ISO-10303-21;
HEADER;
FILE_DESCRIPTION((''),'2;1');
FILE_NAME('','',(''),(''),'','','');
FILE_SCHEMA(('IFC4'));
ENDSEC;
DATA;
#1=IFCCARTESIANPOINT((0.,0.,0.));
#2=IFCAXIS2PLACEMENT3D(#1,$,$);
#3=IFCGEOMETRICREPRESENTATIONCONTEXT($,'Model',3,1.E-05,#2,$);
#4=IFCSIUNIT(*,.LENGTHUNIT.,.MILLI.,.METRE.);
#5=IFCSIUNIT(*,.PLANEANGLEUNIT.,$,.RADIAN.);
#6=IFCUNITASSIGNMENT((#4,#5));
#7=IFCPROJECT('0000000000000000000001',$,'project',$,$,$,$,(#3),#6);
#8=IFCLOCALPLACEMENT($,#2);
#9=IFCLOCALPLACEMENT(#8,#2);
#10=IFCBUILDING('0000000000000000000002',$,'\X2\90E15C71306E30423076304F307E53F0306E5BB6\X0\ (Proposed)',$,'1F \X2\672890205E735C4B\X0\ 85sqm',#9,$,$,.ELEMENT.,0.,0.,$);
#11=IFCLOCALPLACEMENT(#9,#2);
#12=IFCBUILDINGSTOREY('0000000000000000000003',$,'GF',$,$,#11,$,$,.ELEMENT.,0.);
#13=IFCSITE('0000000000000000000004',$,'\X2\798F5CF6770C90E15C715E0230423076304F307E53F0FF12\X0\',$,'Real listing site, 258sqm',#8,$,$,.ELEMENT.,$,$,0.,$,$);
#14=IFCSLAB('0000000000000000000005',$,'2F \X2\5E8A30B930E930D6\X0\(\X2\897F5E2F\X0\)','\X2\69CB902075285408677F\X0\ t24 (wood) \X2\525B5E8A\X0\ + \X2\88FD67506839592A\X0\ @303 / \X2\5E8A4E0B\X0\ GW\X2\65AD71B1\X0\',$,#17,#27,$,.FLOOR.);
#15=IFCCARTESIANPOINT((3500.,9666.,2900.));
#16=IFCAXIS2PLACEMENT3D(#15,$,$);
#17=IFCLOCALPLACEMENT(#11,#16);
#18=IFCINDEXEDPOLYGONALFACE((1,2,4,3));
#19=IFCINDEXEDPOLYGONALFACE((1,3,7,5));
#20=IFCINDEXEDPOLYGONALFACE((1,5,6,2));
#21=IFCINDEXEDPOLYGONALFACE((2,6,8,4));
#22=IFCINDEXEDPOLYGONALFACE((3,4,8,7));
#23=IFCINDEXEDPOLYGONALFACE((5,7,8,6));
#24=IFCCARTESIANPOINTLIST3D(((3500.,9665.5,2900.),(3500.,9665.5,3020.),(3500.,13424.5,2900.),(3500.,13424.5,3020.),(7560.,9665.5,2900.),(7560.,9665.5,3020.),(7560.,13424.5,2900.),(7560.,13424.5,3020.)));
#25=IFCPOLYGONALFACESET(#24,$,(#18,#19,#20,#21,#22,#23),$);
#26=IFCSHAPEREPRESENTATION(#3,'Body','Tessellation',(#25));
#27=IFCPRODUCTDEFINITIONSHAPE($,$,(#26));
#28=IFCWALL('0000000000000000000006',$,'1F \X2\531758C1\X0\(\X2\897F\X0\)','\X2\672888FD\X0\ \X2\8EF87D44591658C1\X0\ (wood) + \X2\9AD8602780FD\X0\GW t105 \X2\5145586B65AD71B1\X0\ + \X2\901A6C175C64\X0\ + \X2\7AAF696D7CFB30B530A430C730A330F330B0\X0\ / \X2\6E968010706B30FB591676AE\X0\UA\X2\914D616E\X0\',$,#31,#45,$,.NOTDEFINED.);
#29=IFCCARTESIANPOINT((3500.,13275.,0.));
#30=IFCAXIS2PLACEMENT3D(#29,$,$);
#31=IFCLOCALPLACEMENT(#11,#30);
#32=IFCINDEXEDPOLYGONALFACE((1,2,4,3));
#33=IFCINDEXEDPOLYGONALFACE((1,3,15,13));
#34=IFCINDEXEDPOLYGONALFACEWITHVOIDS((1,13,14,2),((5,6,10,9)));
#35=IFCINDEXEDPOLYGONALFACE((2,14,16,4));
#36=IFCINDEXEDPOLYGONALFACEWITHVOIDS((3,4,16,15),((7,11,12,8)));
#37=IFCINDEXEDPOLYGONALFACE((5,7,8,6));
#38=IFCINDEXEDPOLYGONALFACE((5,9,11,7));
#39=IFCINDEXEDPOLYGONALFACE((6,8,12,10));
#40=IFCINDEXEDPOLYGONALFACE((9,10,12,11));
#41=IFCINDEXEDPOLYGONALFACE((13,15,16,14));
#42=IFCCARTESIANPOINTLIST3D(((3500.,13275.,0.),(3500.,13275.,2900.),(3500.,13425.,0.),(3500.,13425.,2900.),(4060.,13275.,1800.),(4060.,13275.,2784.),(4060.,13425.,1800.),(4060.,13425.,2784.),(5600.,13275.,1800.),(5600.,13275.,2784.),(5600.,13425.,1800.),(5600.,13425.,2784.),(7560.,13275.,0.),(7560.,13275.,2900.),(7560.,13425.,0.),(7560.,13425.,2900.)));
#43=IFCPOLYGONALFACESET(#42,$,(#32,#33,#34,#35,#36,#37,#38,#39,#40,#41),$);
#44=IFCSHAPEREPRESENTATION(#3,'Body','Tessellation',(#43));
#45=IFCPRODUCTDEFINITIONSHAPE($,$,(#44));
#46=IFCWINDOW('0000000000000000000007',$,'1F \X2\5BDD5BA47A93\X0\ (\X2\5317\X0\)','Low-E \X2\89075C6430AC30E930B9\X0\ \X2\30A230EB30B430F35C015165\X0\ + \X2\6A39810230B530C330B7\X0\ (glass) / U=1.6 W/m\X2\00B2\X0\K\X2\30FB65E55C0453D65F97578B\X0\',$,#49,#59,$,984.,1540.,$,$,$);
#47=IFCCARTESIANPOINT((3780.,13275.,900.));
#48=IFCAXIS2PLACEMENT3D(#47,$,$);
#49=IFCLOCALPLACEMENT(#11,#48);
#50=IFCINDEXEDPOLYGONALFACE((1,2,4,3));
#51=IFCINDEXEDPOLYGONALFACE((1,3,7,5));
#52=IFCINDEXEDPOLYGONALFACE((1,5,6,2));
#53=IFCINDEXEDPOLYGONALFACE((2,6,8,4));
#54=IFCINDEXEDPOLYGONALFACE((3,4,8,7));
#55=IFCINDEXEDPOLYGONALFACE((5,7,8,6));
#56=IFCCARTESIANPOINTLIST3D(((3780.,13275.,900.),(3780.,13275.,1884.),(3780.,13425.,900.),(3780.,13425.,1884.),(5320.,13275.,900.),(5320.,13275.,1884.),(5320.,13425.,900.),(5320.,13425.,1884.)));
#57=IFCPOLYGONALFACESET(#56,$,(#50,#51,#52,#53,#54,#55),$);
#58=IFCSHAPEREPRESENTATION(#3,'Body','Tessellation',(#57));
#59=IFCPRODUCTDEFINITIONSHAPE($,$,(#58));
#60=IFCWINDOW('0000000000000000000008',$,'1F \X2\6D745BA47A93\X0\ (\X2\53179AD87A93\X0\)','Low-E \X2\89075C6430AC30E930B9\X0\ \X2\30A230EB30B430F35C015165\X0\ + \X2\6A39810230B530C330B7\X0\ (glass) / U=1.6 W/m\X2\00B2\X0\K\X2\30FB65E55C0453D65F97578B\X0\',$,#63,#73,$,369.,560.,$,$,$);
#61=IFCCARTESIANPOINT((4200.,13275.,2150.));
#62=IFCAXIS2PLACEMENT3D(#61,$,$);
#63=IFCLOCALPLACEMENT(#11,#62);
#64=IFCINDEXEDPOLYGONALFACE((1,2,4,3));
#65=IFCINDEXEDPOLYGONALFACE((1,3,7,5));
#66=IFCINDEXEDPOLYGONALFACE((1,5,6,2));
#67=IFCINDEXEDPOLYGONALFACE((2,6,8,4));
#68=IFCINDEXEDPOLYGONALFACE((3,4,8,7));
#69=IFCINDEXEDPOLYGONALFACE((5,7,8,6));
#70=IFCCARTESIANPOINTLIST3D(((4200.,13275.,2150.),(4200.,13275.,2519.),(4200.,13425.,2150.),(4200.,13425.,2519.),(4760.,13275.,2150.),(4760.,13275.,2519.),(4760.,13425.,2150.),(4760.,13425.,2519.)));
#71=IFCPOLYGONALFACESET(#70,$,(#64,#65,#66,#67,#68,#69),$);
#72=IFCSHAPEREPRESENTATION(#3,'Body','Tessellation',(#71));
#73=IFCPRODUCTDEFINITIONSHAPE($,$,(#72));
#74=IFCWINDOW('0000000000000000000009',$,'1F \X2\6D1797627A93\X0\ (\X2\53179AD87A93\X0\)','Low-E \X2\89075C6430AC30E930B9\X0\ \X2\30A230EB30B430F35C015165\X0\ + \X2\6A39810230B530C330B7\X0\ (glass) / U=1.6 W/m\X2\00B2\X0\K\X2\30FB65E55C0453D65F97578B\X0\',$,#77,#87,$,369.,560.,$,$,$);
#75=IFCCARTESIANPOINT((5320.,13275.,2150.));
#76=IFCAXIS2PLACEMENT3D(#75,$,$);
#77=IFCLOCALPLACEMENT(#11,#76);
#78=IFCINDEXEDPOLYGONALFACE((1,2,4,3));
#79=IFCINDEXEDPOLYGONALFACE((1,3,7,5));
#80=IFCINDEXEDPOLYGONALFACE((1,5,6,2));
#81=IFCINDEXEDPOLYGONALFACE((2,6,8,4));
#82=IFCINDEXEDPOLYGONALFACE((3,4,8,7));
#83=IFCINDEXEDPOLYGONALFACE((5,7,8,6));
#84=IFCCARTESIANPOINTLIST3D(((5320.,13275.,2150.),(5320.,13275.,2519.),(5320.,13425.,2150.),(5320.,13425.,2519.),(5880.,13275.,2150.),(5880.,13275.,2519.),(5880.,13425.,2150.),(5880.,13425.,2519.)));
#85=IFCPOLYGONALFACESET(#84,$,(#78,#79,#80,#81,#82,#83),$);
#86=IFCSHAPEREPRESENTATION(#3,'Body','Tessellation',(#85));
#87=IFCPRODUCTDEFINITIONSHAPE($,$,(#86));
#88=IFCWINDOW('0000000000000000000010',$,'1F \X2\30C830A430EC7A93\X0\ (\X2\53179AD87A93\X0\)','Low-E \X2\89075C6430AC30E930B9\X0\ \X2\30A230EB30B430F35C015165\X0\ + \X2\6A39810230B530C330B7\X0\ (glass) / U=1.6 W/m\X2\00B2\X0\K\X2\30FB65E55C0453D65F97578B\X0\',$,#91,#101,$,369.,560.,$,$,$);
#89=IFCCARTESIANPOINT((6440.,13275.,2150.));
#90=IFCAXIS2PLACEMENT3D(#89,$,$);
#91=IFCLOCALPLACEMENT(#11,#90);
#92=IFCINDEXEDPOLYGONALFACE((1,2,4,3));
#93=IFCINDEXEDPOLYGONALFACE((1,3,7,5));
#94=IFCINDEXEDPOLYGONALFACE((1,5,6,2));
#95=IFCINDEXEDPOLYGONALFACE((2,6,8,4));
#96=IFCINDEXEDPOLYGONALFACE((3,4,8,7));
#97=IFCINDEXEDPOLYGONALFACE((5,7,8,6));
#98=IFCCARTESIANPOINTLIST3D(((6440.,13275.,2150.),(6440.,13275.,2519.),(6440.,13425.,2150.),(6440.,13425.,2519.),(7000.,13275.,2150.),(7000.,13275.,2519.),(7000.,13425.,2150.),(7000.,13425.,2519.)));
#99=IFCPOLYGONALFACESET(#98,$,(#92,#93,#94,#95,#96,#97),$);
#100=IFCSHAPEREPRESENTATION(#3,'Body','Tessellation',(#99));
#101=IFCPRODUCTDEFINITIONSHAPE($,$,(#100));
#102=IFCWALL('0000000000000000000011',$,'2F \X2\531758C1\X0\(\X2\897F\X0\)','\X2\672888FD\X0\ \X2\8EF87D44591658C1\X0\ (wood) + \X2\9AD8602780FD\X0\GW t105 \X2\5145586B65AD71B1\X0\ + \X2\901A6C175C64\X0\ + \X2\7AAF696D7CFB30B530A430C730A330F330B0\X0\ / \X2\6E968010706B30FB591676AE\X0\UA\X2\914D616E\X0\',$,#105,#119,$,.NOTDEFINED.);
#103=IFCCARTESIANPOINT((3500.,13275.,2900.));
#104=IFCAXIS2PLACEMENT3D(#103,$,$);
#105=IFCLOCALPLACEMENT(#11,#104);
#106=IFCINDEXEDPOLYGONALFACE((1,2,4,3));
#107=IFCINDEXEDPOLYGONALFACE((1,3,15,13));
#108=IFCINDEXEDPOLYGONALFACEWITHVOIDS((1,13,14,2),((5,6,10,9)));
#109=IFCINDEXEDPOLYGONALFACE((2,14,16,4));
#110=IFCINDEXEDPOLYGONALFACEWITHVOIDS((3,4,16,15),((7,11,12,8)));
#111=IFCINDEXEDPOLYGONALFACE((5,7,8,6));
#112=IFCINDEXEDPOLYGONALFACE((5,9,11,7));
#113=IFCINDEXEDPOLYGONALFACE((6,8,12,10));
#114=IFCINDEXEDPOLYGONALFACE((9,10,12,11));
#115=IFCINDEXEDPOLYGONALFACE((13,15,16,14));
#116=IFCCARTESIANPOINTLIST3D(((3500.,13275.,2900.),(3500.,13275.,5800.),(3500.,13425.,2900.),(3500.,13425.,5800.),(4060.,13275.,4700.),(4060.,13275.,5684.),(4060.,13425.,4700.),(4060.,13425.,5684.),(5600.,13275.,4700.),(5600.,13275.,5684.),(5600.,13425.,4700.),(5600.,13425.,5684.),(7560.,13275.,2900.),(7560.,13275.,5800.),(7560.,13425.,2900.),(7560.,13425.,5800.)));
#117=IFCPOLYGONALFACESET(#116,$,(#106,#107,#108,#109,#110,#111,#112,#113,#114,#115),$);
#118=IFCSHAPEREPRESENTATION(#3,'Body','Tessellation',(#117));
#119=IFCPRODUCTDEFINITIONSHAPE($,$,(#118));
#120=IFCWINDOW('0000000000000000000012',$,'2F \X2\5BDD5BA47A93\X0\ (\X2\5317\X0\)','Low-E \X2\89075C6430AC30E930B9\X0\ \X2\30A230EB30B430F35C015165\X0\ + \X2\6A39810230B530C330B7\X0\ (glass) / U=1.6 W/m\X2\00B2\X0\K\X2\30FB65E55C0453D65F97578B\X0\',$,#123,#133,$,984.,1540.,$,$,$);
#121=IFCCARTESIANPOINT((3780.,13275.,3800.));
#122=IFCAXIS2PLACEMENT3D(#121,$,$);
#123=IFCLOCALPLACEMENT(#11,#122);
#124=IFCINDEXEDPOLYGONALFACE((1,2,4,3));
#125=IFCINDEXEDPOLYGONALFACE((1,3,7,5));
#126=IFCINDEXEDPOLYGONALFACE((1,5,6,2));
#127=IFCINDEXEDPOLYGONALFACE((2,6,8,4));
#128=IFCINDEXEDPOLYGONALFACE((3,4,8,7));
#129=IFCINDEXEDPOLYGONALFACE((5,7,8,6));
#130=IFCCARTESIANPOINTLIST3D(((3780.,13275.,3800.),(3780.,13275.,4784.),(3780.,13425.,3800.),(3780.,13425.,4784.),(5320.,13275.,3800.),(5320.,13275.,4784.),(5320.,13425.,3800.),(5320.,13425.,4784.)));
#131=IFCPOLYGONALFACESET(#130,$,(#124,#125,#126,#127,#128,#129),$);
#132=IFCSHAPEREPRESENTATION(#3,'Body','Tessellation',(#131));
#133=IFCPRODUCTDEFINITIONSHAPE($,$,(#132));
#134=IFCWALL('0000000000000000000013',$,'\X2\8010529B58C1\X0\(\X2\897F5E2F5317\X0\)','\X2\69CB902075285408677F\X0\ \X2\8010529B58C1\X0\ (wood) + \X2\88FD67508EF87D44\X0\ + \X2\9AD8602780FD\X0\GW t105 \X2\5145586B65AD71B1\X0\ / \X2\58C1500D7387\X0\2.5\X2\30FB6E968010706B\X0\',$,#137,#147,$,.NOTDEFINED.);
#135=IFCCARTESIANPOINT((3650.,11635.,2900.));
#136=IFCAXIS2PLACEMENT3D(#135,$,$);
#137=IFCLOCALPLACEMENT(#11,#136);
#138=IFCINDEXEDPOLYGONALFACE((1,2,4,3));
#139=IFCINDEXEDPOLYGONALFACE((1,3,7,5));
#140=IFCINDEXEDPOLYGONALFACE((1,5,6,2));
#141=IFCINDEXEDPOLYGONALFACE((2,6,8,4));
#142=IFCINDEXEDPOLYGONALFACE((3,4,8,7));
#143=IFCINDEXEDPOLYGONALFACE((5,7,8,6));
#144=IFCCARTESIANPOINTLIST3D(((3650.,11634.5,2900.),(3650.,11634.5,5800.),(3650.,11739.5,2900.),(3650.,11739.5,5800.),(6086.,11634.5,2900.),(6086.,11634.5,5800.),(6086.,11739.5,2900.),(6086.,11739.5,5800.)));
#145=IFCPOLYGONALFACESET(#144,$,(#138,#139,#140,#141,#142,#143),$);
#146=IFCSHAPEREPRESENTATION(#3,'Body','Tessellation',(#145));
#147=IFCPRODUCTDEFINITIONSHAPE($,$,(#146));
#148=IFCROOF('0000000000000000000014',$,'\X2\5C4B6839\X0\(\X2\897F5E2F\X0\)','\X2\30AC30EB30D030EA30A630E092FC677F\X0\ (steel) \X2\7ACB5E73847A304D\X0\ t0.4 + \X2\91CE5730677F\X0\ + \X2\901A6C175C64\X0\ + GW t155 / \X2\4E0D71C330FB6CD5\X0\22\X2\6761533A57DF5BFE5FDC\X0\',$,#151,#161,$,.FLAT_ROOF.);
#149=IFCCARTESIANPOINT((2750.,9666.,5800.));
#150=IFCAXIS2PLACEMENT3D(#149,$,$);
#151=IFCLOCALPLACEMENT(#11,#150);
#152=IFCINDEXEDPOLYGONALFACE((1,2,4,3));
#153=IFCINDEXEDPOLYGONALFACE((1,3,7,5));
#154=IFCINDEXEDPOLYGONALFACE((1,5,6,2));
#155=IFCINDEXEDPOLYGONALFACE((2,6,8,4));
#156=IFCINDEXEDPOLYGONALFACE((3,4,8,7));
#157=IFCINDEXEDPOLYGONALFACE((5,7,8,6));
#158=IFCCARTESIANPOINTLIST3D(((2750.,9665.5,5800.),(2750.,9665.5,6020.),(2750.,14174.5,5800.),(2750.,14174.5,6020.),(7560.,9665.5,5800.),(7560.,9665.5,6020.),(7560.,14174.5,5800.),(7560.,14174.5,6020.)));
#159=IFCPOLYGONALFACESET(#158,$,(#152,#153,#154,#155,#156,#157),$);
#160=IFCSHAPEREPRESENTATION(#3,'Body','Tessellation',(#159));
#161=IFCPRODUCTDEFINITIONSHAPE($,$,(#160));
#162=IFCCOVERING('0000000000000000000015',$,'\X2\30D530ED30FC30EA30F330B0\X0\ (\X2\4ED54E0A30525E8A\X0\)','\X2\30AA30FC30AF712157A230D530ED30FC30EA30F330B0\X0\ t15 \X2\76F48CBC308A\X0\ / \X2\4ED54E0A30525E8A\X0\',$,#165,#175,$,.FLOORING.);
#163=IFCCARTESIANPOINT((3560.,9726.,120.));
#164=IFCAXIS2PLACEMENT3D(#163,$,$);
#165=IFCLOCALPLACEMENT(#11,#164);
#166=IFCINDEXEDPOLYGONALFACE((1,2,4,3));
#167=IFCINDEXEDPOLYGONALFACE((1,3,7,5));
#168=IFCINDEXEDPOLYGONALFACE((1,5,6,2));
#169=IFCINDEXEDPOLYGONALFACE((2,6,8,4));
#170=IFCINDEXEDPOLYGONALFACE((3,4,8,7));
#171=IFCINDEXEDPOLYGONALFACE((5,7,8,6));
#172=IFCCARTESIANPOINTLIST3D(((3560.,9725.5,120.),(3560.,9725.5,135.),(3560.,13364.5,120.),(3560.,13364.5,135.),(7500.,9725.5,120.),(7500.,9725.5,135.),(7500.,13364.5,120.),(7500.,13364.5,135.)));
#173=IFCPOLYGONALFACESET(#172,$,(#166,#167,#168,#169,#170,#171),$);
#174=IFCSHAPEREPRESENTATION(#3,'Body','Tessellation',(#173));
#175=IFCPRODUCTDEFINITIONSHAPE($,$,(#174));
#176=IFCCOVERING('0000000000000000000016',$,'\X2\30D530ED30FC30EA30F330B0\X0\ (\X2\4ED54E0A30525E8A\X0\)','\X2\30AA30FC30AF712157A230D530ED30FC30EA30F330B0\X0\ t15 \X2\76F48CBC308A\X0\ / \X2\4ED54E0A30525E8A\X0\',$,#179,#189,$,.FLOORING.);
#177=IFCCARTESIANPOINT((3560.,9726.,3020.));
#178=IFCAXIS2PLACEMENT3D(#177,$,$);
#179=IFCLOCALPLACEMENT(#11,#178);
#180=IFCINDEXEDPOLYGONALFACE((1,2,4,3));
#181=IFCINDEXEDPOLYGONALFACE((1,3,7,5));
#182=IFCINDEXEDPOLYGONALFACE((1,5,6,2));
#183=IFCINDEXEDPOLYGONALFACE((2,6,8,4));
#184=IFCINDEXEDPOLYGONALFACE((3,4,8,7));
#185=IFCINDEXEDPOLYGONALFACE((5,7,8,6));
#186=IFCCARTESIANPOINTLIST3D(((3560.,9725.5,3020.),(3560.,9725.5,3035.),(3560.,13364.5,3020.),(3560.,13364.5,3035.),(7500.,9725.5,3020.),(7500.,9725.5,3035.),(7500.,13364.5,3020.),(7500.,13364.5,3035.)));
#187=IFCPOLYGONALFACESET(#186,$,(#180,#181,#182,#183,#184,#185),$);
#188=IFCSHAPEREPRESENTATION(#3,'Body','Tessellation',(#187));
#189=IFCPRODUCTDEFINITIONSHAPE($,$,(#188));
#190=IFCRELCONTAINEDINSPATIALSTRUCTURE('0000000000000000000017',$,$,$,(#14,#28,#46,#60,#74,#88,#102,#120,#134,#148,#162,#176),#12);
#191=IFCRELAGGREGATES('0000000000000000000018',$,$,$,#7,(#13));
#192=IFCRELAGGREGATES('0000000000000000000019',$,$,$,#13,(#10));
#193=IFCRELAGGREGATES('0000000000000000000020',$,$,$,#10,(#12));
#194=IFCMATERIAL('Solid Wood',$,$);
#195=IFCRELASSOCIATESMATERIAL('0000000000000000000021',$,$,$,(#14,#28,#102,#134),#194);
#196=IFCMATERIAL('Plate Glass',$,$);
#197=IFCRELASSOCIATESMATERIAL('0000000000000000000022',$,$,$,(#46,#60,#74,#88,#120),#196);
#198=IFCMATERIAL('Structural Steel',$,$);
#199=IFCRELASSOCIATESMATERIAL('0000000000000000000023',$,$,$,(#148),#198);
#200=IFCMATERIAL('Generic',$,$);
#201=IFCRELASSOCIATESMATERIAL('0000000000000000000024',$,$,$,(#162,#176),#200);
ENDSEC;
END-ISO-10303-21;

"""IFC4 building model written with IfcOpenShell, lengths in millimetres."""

from ifc_helpers import new_model, si_unit, frame, frame_2d, origin, place, context, project, spatial, rectangle, extrude, material, element, fill, save


model = new_model("IFC4")

# Units and contexts
model_context = context("Model", 3, precision=1e-05, world=origin())
ifc_project = project(units=[si_unit("LENGTHUNIT", "METRE", prefix="MILLI"), si_unit("PLANEANGLEUNIT", "RADIAN")], contexts=[model_context])

# Site, building, storey
site_placement = place(None, origin())
site = spatial("IfcSite", under=ifc_project, at=site_placement, Name="福島県郡山市あぶくま台２", ObjectType="Real listing site, 258sqm", CompositionType="ELEMENT", RefElevation=0.0)
building_placement = place(site_placement, origin())
building = spatial("IfcBuilding", under=site, at=building_placement, Name="郡山のあぶくま台の家 (Proposed)", ObjectType="1F 木造平屋 85sqm", CompositionType="ELEMENT", ElevationOfRefHeight=0.0, ElevationOfTerrain=0.0)
storey_placement = place(building_placement, origin())
storey = spatial("IfcBuildingStorey", under=building, at=storey_placement, Name="GF", CompositionType="ELEMENT", Elevation=0.0)

# Slab
ifc_material_1 = material(Name="Solid Wood")
slab_1_placement = place(storey_placement, frame((3500.0, 9666.0, 2900.0)))
element("IfcSlab", 1, at=slab_1_placement, inside=storey, material=ifc_material_1, Name="2F 床スラブ(西帯)", Description="構造用合板 t24 (wood) 剛床 + 製材根太 @303 / 床下 GW断熱", PredefinedType="FLOOR", context=model_context, shape_type="SweptSolid", body=[
    extrude(rectangle(XDim=4060.0, YDim=3759.0, at=frame_2d((2030.0, 1879.0))), frame((3500.0, 9666.0, 2900.0)), (0.0, 0.0, 1.0), 120.0),
])

# Wall, openings, windows
wall_1_placement = place(storey_placement, frame((3500.0, 13275.0, 0.0)))
wall_1 = element("IfcWall", 2, at=wall_1_placement, inside=storey, material=ifc_material_1, Name="1F 北壁(西)", Description="木製 軸組外壁 (wood) + 高性能GW t105 充填断熱 + 通気層 + 窯業系サイディング / 準耐火・外皮UA配慮", PredefinedType="NOTDEFINED", context=model_context, shape_type="SweptSolid", body=[
    extrude(rectangle(XDim=4060.0, YDim=150.0, at=frame_2d((2030.0, 75.0))), frame((3500.0, 13275.0, 0.0)), (0.0, 0.0, 1.0), 2900.0),
])
opening_1_placement = place(storey_placement, frame((3780.0, 13275.0, 900.0)))
opening_1 = element("IfcOpeningElement", 3, at=opening_1_placement, cuts=wall_1, PredefinedType="NOTDEFINED", context=model_context, shape_type="SweptSolid", body=[
    extrude(rectangle(XDim=1540.0, YDim=150.0, at=frame_2d((770.0, 75.0))), frame((3780.0, 13275.0, 900.0)), (0.0, 0.0, 1.0), 984.0),
])
opening_2_placement = place(storey_placement, frame((4200.0, 13275.0, 2150.0)))
opening_2 = element("IfcOpeningElement", 4, at=opening_2_placement, cuts=wall_1, PredefinedType="NOTDEFINED", context=model_context, shape_type="SweptSolid", body=[
    extrude(rectangle(XDim=560.0, YDim=150.0, at=frame_2d((280.0, 75.0))), frame((4200.0, 13275.0, 2150.0)), (0.0, 0.0, 1.0), 369.0),
])
opening_3_placement = place(storey_placement, frame((5320.0, 13275.0, 2150.0)))
opening_3 = element("IfcOpeningElement", 5, at=opening_3_placement, cuts=wall_1, PredefinedType="NOTDEFINED", context=model_context, shape_type="SweptSolid", body=[
    extrude(rectangle(XDim=560.0, YDim=150.0, at=frame_2d((280.0, 75.0))), frame((5320.0, 13275.0, 2150.0)), (0.0, 0.0, 1.0), 369.0),
])
opening_4_placement = place(storey_placement, frame((6440.0, 13275.0, 2150.0)))
opening_4 = element("IfcOpeningElement", 6, at=opening_4_placement, cuts=wall_1, PredefinedType="NOTDEFINED", context=model_context, shape_type="SweptSolid", body=[
    extrude(rectangle(XDim=560.0, YDim=150.0, at=frame_2d((280.0, 75.0))), frame((6440.0, 13275.0, 2150.0)), (0.0, 0.0, 1.0), 369.0),
])
ifc_material_2 = material(Name="Plate Glass")
window_1_placement = place(storey_placement, frame((3780.0, 13275.0, 900.0)))
window_1 = element("IfcWindow", 7, at=window_1_placement, inside=storey, material=ifc_material_2, Name="1F 寝室窓 (北)", Description="Low-E 複層ガラス アルゴン封入 + 樹脂サッシ (glass) / U=1.6 W/m²K・日射取得型", OverallHeight=984.0, OverallWidth=1540.0, context=model_context, shape_type="SweptSolid", body=[
    extrude(rectangle(XDim=1540.0, YDim=150.0, at=frame_2d((770.0, 75.0))), frame((3780.0, 13275.0, 900.0)), (0.0, 0.0, 1.0), 984.0),
])
fill(opening_1, window_1)
window_2_placement = place(storey_placement, frame((4200.0, 13275.0, 2150.0)))
window_2 = element("IfcWindow", 8, at=window_2_placement, inside=storey, material=ifc_material_2, Name="1F 浴室窓 (北高窓)", Description="Low-E 複層ガラス アルゴン封入 + 樹脂サッシ (glass) / U=1.6 W/m²K・日射取得型", OverallHeight=369.0, OverallWidth=560.0, context=model_context, shape_type="SweptSolid", body=[
    extrude(rectangle(XDim=560.0, YDim=150.0, at=frame_2d((280.0, 75.0))), frame((4200.0, 13275.0, 2150.0)), (0.0, 0.0, 1.0), 369.0),
])
fill(opening_2, window_2)
window_3_placement = place(storey_placement, frame((5320.0, 13275.0, 2150.0)))
window_3 = element("IfcWindow", 9, at=window_3_placement, inside=storey, material=ifc_material_2, Name="1F 洗面窓 (北高窓)", Description="Low-E 複層ガラス アルゴン封入 + 樹脂サッシ (glass) / U=1.6 W/m²K・日射取得型", OverallHeight=369.0, OverallWidth=560.0, context=model_context, shape_type="SweptSolid", body=[
    extrude(rectangle(XDim=560.0, YDim=150.0, at=frame_2d((280.0, 75.0))), frame((5320.0, 13275.0, 2150.0)), (0.0, 0.0, 1.0), 369.0),
])
fill(opening_3, window_3)
window_4_placement = place(storey_placement, frame((6440.0, 13275.0, 2150.0)))
window_4 = element("IfcWindow", 10, at=window_4_placement, inside=storey, material=ifc_material_2, Name="1F トイレ窓 (北高窓)", Description="Low-E 複層ガラス アルゴン封入 + 樹脂サッシ (glass) / U=1.6 W/m²K・日射取得型", OverallHeight=369.0, OverallWidth=560.0, context=model_context, shape_type="SweptSolid", body=[
    extrude(rectangle(XDim=560.0, YDim=150.0, at=frame_2d((280.0, 75.0))), frame((6440.0, 13275.0, 2150.0)), (0.0, 0.0, 1.0), 369.0),
])
fill(opening_4, window_4)

# Wall, opening, window
wall_2_placement = place(storey_placement, frame((3500.0, 13275.0, 2900.0)))
wall_2 = element("IfcWall", 11, at=wall_2_placement, inside=storey, material=ifc_material_1, Name="2F 北壁(西)", Description="木製 軸組外壁 (wood) + 高性能GW t105 充填断熱 + 通気層 + 窯業系サイディング / 準耐火・外皮UA配慮", PredefinedType="NOTDEFINED", context=model_context, shape_type="SweptSolid", body=[
    extrude(rectangle(XDim=4060.0, YDim=150.0, at=frame_2d((2030.0, 75.0))), frame((3500.0, 13275.0, 2900.0)), (0.0, 0.0, 1.0), 2900.0),
])
opening_5_placement = place(storey_placement, frame((3780.0, 13275.0, 3800.0)))
opening_5 = element("IfcOpeningElement", 12, at=opening_5_placement, cuts=wall_2, PredefinedType="NOTDEFINED", context=model_context, shape_type="SweptSolid", body=[
    extrude(rectangle(XDim=1540.0, YDim=150.0, at=frame_2d((770.0, 75.0))), frame((3780.0, 13275.0, 3800.0)), (0.0, 0.0, 1.0), 984.0),
])
window_5_placement = place(storey_placement, frame((3780.0, 13275.0, 3800.0)))
window_5 = element("IfcWindow", 13, at=window_5_placement, inside=storey, material=ifc_material_2, Name="2F 寝室窓 (北)", Description="Low-E 複層ガラス アルゴン封入 + 樹脂サッシ (glass) / U=1.6 W/m²K・日射取得型", OverallHeight=984.0, OverallWidth=1540.0, context=model_context, shape_type="SweptSolid", body=[
    extrude(rectangle(XDim=1540.0, YDim=150.0, at=frame_2d((770.0, 75.0))), frame((3780.0, 13275.0, 3800.0)), (0.0, 0.0, 1.0), 984.0),
])
fill(opening_5, window_5)

# Wall
wall_3_placement = place(storey_placement, frame((3650.0, 11635.0, 2900.0)))
element("IfcWall", 14, at=wall_3_placement, inside=storey, material=ifc_material_1, Name="耐力壁(西帯北)", Description="構造用合板 耐力壁 (wood) + 製材軸組 + 高性能GW t105 充填断熱 / 壁倍率2.5・準耐火", PredefinedType="NOTDEFINED", context=model_context, shape_type="SweptSolid", body=[
    extrude(rectangle(XDim=2436.0, YDim=105.0, at=frame_2d((1218.0, 52.0))), frame((3650.0, 11635.0, 2900.0)), (0.0, 0.0, 1.0), 2900.0),
])

# Roof
ifc_material_3 = material(Name="Structural Steel")
for number, where, name in (
    (15, (2750.0, 9666.0, 5800.0), "屋根(西帯)"),
):
    element("IfcRoof", number, at=place(storey_placement, frame(where)), inside=storey, material=ifc_material_3, Name=name, Description="ガルバリウム鋼板 (steel) 立平葺き t0.4 + 野地板 + 通気層 + GW t155 / 不燃・法22条区域対応", PredefinedType="FLAT_ROOF", context=model_context, shape_type="SweptSolid", body=[
        extrude(rectangle(XDim=4810.0, YDim=4509.0, at=frame_2d((2405.0, 2254.0))), frame((2750.0, 9666.0, 5800.0)), (0.0, 0.0, 1.0), 220.0),
    ])

# Coverings
ifc_material_4 = material(Name="Generic")
covering_1_placement = place(storey_placement, frame((3560.0, 9726.0, 120.0)))
element("IfcCovering", 16, at=covering_1_placement, inside=storey, material=ifc_material_4, Name="フローリング (仕上げ床)", Description="オーク無垢フローリング t15 直貼り / 仕上げ床", PredefinedType="FLOORING", context=model_context, shape_type="SweptSolid", body=[
    extrude(rectangle(XDim=3940.0, YDim=3639.0, at=frame_2d((1970.0, 1819.0))), frame((3560.0, 9726.0, 120.0)), (0.0, 0.0, 1.0), 15.0),
])
covering_2_placement = place(storey_placement, frame((3560.0, 9726.0, 3020.0)))
element("IfcCovering", 17, at=covering_2_placement, inside=storey, material=ifc_material_4, Name="フローリング (仕上げ床)", Description="オーク無垢フローリング t15 直貼り / 仕上げ床", PredefinedType="FLOORING", context=model_context, shape_type="SweptSolid", body=[
    extrude(rectangle(XDim=3940.0, YDim=3639.0, at=frame_2d((1970.0, 1819.0))), frame((3560.0, 9726.0, 3020.0)), (0.0, 0.0, 1.0), 15.0),
])

save(model, "model.ifc")
